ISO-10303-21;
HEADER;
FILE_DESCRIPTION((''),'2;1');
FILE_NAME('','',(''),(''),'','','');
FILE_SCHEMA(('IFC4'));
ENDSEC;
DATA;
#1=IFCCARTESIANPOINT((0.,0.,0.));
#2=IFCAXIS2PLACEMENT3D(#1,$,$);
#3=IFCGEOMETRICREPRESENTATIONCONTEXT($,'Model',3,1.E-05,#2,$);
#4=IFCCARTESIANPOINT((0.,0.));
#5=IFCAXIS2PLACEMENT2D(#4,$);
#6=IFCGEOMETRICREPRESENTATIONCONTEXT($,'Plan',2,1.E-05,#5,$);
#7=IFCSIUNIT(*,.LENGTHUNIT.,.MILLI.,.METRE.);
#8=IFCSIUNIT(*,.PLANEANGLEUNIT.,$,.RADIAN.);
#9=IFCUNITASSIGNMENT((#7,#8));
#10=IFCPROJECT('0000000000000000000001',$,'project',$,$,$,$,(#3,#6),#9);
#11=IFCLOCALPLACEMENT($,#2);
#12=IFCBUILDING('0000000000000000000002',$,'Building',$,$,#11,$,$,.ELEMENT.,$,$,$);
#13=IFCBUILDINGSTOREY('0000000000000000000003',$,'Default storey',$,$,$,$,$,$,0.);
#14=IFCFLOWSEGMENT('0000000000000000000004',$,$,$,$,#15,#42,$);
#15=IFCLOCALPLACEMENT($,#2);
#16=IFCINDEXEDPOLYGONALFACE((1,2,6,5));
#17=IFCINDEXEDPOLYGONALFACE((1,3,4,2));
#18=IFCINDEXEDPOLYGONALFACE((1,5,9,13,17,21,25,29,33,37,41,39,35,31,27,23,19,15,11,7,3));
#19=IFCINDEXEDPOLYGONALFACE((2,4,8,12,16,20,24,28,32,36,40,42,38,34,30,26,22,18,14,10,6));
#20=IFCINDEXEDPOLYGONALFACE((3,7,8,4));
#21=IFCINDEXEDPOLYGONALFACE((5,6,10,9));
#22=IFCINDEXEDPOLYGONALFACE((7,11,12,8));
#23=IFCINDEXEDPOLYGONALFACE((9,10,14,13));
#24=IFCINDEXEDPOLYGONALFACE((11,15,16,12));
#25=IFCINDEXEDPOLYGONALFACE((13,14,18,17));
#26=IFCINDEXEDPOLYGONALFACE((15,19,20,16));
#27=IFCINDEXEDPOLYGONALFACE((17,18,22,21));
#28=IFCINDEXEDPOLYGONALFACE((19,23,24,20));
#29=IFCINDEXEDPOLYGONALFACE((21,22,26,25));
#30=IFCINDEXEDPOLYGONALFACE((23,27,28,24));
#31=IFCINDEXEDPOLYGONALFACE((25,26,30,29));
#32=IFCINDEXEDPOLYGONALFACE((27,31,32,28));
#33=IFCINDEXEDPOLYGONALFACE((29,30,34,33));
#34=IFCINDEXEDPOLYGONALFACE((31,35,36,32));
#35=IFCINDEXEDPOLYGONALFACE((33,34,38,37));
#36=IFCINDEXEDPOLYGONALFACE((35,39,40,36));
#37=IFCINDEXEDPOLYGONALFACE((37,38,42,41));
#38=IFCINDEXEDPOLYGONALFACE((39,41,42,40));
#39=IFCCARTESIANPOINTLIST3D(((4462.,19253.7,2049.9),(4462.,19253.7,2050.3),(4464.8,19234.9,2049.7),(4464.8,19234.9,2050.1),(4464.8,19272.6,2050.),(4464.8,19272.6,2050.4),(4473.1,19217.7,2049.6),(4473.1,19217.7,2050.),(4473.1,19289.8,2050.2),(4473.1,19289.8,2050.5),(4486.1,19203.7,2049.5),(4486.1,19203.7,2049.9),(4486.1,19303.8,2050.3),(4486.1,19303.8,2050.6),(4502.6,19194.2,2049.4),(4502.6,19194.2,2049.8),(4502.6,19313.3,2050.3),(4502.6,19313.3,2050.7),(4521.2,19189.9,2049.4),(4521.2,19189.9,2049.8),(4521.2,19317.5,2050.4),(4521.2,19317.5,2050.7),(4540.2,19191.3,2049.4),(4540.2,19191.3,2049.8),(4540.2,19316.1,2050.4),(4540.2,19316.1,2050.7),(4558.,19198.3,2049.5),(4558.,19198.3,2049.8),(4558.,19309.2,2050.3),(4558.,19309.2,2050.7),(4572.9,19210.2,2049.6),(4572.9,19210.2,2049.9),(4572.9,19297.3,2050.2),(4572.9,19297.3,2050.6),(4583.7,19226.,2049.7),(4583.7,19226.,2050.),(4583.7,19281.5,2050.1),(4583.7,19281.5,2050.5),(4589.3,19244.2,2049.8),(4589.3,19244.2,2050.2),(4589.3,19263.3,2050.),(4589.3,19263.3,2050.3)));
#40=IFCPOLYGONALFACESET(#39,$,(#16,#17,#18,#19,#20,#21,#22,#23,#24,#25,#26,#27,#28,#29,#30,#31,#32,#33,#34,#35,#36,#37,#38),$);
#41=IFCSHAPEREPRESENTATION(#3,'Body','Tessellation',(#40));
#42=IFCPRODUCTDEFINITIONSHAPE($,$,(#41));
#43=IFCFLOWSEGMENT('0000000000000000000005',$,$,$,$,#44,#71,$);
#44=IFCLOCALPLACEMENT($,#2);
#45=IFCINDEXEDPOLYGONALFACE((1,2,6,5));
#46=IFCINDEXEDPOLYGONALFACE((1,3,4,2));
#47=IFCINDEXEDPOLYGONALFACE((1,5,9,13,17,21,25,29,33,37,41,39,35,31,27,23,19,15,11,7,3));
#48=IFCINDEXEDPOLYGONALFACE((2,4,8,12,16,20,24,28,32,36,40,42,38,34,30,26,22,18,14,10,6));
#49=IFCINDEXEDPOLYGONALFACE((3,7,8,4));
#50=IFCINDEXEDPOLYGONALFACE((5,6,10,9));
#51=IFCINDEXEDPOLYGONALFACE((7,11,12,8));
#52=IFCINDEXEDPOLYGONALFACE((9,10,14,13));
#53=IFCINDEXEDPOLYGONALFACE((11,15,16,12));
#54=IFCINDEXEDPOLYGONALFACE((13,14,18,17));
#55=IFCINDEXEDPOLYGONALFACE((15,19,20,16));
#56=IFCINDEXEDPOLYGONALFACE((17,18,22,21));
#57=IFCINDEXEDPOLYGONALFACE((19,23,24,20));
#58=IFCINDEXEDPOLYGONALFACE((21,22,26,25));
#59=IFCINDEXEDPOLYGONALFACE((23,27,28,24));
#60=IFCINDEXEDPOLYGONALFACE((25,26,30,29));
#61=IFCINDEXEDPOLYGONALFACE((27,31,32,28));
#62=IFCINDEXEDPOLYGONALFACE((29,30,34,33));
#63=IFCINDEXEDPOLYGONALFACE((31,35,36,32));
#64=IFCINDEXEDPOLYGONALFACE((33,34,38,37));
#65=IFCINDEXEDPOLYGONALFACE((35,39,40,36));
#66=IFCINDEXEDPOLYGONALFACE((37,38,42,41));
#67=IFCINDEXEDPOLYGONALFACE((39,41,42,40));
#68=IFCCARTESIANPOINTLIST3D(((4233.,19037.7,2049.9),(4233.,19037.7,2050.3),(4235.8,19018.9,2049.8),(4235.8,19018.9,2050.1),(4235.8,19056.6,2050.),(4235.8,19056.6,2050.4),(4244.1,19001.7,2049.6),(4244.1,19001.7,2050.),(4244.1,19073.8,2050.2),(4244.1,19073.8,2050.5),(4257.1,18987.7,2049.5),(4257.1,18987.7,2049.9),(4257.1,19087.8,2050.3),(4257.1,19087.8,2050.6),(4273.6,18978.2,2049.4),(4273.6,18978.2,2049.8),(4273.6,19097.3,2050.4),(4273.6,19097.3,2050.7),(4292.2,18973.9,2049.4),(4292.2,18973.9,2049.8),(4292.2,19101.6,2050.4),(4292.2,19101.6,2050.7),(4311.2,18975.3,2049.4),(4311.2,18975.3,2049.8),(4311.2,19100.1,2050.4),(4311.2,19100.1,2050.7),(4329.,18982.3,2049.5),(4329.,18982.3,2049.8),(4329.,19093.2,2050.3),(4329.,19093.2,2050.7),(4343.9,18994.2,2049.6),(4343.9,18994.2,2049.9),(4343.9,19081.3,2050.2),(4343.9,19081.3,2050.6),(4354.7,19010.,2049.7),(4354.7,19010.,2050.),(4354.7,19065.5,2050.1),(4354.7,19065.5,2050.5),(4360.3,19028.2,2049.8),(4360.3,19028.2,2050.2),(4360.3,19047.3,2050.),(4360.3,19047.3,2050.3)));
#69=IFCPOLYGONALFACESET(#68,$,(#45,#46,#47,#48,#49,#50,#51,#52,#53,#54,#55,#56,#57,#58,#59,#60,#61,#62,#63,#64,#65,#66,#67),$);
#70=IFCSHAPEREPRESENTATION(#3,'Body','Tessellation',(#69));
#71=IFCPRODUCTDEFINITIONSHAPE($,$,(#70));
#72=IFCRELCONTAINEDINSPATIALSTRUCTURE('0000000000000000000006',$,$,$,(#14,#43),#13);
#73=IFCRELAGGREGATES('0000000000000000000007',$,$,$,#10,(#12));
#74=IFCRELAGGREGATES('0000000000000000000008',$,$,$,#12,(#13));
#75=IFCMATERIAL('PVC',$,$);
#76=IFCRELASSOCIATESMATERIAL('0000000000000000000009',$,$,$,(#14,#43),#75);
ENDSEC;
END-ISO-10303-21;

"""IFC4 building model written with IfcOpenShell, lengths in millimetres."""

from ifc_helpers import new_model, si_unit, frame, origin, origin_2d, place, context, project, spatial, circle, extrude, material, element, save


model = new_model("IFC4")

# Units and contexts
model_context = context("Model", 3, precision=1e-05, world=origin())
plan_context = context("Plan", 2, precision=1e-05, world=origin_2d())
ifc_project = project(units=[si_unit("LENGTHUNIT", "METRE", prefix="MILLI"), si_unit("PLANEANGLEUNIT", "RADIAN")], contexts=[model_context, plan_context])

# Building, storey
placement = place(None, origin())
building = spatial("IfcBuilding", under=ifc_project, at=placement, Name="Building", CompositionType="ELEMENT")
storey = spatial("IfcBuildingStorey", under=building, Name="Default storey", Elevation=0.0)

# Flow segments
ifc_material_1 = material(Name="PVC")
element("IfcFlowSegment", 1, at=placement, inside=storey, material=ifc_material_1, context=model_context, shape_type="SweptSolid", body=[
    extrude(circle(Radius=64.0, at=origin_2d()), frame((4526.0, 19253.7, 2049.9), z_axis=(0.0, -0.002726, 0.362527), x_axis=(-2.72577, 0.0, 0.0)), (0.0, 0.0, 1.0), 0.4),
])
element("IfcFlowSegment", 2, at=placement, inside=storey, material=ifc_material_1, context=model_context, shape_type="SweptSolid", body=[
    extrude(circle(Radius=64.0, at=origin_2d()), frame((4297.0, 19037.7, 2049.9), z_axis=(0.0, -0.002671, 0.352528), x_axis=(-2.670665, 0.0, 0.0)), (0.0, 0.0, 1.0), 0.4),
])

save(model, "model.ifc")
